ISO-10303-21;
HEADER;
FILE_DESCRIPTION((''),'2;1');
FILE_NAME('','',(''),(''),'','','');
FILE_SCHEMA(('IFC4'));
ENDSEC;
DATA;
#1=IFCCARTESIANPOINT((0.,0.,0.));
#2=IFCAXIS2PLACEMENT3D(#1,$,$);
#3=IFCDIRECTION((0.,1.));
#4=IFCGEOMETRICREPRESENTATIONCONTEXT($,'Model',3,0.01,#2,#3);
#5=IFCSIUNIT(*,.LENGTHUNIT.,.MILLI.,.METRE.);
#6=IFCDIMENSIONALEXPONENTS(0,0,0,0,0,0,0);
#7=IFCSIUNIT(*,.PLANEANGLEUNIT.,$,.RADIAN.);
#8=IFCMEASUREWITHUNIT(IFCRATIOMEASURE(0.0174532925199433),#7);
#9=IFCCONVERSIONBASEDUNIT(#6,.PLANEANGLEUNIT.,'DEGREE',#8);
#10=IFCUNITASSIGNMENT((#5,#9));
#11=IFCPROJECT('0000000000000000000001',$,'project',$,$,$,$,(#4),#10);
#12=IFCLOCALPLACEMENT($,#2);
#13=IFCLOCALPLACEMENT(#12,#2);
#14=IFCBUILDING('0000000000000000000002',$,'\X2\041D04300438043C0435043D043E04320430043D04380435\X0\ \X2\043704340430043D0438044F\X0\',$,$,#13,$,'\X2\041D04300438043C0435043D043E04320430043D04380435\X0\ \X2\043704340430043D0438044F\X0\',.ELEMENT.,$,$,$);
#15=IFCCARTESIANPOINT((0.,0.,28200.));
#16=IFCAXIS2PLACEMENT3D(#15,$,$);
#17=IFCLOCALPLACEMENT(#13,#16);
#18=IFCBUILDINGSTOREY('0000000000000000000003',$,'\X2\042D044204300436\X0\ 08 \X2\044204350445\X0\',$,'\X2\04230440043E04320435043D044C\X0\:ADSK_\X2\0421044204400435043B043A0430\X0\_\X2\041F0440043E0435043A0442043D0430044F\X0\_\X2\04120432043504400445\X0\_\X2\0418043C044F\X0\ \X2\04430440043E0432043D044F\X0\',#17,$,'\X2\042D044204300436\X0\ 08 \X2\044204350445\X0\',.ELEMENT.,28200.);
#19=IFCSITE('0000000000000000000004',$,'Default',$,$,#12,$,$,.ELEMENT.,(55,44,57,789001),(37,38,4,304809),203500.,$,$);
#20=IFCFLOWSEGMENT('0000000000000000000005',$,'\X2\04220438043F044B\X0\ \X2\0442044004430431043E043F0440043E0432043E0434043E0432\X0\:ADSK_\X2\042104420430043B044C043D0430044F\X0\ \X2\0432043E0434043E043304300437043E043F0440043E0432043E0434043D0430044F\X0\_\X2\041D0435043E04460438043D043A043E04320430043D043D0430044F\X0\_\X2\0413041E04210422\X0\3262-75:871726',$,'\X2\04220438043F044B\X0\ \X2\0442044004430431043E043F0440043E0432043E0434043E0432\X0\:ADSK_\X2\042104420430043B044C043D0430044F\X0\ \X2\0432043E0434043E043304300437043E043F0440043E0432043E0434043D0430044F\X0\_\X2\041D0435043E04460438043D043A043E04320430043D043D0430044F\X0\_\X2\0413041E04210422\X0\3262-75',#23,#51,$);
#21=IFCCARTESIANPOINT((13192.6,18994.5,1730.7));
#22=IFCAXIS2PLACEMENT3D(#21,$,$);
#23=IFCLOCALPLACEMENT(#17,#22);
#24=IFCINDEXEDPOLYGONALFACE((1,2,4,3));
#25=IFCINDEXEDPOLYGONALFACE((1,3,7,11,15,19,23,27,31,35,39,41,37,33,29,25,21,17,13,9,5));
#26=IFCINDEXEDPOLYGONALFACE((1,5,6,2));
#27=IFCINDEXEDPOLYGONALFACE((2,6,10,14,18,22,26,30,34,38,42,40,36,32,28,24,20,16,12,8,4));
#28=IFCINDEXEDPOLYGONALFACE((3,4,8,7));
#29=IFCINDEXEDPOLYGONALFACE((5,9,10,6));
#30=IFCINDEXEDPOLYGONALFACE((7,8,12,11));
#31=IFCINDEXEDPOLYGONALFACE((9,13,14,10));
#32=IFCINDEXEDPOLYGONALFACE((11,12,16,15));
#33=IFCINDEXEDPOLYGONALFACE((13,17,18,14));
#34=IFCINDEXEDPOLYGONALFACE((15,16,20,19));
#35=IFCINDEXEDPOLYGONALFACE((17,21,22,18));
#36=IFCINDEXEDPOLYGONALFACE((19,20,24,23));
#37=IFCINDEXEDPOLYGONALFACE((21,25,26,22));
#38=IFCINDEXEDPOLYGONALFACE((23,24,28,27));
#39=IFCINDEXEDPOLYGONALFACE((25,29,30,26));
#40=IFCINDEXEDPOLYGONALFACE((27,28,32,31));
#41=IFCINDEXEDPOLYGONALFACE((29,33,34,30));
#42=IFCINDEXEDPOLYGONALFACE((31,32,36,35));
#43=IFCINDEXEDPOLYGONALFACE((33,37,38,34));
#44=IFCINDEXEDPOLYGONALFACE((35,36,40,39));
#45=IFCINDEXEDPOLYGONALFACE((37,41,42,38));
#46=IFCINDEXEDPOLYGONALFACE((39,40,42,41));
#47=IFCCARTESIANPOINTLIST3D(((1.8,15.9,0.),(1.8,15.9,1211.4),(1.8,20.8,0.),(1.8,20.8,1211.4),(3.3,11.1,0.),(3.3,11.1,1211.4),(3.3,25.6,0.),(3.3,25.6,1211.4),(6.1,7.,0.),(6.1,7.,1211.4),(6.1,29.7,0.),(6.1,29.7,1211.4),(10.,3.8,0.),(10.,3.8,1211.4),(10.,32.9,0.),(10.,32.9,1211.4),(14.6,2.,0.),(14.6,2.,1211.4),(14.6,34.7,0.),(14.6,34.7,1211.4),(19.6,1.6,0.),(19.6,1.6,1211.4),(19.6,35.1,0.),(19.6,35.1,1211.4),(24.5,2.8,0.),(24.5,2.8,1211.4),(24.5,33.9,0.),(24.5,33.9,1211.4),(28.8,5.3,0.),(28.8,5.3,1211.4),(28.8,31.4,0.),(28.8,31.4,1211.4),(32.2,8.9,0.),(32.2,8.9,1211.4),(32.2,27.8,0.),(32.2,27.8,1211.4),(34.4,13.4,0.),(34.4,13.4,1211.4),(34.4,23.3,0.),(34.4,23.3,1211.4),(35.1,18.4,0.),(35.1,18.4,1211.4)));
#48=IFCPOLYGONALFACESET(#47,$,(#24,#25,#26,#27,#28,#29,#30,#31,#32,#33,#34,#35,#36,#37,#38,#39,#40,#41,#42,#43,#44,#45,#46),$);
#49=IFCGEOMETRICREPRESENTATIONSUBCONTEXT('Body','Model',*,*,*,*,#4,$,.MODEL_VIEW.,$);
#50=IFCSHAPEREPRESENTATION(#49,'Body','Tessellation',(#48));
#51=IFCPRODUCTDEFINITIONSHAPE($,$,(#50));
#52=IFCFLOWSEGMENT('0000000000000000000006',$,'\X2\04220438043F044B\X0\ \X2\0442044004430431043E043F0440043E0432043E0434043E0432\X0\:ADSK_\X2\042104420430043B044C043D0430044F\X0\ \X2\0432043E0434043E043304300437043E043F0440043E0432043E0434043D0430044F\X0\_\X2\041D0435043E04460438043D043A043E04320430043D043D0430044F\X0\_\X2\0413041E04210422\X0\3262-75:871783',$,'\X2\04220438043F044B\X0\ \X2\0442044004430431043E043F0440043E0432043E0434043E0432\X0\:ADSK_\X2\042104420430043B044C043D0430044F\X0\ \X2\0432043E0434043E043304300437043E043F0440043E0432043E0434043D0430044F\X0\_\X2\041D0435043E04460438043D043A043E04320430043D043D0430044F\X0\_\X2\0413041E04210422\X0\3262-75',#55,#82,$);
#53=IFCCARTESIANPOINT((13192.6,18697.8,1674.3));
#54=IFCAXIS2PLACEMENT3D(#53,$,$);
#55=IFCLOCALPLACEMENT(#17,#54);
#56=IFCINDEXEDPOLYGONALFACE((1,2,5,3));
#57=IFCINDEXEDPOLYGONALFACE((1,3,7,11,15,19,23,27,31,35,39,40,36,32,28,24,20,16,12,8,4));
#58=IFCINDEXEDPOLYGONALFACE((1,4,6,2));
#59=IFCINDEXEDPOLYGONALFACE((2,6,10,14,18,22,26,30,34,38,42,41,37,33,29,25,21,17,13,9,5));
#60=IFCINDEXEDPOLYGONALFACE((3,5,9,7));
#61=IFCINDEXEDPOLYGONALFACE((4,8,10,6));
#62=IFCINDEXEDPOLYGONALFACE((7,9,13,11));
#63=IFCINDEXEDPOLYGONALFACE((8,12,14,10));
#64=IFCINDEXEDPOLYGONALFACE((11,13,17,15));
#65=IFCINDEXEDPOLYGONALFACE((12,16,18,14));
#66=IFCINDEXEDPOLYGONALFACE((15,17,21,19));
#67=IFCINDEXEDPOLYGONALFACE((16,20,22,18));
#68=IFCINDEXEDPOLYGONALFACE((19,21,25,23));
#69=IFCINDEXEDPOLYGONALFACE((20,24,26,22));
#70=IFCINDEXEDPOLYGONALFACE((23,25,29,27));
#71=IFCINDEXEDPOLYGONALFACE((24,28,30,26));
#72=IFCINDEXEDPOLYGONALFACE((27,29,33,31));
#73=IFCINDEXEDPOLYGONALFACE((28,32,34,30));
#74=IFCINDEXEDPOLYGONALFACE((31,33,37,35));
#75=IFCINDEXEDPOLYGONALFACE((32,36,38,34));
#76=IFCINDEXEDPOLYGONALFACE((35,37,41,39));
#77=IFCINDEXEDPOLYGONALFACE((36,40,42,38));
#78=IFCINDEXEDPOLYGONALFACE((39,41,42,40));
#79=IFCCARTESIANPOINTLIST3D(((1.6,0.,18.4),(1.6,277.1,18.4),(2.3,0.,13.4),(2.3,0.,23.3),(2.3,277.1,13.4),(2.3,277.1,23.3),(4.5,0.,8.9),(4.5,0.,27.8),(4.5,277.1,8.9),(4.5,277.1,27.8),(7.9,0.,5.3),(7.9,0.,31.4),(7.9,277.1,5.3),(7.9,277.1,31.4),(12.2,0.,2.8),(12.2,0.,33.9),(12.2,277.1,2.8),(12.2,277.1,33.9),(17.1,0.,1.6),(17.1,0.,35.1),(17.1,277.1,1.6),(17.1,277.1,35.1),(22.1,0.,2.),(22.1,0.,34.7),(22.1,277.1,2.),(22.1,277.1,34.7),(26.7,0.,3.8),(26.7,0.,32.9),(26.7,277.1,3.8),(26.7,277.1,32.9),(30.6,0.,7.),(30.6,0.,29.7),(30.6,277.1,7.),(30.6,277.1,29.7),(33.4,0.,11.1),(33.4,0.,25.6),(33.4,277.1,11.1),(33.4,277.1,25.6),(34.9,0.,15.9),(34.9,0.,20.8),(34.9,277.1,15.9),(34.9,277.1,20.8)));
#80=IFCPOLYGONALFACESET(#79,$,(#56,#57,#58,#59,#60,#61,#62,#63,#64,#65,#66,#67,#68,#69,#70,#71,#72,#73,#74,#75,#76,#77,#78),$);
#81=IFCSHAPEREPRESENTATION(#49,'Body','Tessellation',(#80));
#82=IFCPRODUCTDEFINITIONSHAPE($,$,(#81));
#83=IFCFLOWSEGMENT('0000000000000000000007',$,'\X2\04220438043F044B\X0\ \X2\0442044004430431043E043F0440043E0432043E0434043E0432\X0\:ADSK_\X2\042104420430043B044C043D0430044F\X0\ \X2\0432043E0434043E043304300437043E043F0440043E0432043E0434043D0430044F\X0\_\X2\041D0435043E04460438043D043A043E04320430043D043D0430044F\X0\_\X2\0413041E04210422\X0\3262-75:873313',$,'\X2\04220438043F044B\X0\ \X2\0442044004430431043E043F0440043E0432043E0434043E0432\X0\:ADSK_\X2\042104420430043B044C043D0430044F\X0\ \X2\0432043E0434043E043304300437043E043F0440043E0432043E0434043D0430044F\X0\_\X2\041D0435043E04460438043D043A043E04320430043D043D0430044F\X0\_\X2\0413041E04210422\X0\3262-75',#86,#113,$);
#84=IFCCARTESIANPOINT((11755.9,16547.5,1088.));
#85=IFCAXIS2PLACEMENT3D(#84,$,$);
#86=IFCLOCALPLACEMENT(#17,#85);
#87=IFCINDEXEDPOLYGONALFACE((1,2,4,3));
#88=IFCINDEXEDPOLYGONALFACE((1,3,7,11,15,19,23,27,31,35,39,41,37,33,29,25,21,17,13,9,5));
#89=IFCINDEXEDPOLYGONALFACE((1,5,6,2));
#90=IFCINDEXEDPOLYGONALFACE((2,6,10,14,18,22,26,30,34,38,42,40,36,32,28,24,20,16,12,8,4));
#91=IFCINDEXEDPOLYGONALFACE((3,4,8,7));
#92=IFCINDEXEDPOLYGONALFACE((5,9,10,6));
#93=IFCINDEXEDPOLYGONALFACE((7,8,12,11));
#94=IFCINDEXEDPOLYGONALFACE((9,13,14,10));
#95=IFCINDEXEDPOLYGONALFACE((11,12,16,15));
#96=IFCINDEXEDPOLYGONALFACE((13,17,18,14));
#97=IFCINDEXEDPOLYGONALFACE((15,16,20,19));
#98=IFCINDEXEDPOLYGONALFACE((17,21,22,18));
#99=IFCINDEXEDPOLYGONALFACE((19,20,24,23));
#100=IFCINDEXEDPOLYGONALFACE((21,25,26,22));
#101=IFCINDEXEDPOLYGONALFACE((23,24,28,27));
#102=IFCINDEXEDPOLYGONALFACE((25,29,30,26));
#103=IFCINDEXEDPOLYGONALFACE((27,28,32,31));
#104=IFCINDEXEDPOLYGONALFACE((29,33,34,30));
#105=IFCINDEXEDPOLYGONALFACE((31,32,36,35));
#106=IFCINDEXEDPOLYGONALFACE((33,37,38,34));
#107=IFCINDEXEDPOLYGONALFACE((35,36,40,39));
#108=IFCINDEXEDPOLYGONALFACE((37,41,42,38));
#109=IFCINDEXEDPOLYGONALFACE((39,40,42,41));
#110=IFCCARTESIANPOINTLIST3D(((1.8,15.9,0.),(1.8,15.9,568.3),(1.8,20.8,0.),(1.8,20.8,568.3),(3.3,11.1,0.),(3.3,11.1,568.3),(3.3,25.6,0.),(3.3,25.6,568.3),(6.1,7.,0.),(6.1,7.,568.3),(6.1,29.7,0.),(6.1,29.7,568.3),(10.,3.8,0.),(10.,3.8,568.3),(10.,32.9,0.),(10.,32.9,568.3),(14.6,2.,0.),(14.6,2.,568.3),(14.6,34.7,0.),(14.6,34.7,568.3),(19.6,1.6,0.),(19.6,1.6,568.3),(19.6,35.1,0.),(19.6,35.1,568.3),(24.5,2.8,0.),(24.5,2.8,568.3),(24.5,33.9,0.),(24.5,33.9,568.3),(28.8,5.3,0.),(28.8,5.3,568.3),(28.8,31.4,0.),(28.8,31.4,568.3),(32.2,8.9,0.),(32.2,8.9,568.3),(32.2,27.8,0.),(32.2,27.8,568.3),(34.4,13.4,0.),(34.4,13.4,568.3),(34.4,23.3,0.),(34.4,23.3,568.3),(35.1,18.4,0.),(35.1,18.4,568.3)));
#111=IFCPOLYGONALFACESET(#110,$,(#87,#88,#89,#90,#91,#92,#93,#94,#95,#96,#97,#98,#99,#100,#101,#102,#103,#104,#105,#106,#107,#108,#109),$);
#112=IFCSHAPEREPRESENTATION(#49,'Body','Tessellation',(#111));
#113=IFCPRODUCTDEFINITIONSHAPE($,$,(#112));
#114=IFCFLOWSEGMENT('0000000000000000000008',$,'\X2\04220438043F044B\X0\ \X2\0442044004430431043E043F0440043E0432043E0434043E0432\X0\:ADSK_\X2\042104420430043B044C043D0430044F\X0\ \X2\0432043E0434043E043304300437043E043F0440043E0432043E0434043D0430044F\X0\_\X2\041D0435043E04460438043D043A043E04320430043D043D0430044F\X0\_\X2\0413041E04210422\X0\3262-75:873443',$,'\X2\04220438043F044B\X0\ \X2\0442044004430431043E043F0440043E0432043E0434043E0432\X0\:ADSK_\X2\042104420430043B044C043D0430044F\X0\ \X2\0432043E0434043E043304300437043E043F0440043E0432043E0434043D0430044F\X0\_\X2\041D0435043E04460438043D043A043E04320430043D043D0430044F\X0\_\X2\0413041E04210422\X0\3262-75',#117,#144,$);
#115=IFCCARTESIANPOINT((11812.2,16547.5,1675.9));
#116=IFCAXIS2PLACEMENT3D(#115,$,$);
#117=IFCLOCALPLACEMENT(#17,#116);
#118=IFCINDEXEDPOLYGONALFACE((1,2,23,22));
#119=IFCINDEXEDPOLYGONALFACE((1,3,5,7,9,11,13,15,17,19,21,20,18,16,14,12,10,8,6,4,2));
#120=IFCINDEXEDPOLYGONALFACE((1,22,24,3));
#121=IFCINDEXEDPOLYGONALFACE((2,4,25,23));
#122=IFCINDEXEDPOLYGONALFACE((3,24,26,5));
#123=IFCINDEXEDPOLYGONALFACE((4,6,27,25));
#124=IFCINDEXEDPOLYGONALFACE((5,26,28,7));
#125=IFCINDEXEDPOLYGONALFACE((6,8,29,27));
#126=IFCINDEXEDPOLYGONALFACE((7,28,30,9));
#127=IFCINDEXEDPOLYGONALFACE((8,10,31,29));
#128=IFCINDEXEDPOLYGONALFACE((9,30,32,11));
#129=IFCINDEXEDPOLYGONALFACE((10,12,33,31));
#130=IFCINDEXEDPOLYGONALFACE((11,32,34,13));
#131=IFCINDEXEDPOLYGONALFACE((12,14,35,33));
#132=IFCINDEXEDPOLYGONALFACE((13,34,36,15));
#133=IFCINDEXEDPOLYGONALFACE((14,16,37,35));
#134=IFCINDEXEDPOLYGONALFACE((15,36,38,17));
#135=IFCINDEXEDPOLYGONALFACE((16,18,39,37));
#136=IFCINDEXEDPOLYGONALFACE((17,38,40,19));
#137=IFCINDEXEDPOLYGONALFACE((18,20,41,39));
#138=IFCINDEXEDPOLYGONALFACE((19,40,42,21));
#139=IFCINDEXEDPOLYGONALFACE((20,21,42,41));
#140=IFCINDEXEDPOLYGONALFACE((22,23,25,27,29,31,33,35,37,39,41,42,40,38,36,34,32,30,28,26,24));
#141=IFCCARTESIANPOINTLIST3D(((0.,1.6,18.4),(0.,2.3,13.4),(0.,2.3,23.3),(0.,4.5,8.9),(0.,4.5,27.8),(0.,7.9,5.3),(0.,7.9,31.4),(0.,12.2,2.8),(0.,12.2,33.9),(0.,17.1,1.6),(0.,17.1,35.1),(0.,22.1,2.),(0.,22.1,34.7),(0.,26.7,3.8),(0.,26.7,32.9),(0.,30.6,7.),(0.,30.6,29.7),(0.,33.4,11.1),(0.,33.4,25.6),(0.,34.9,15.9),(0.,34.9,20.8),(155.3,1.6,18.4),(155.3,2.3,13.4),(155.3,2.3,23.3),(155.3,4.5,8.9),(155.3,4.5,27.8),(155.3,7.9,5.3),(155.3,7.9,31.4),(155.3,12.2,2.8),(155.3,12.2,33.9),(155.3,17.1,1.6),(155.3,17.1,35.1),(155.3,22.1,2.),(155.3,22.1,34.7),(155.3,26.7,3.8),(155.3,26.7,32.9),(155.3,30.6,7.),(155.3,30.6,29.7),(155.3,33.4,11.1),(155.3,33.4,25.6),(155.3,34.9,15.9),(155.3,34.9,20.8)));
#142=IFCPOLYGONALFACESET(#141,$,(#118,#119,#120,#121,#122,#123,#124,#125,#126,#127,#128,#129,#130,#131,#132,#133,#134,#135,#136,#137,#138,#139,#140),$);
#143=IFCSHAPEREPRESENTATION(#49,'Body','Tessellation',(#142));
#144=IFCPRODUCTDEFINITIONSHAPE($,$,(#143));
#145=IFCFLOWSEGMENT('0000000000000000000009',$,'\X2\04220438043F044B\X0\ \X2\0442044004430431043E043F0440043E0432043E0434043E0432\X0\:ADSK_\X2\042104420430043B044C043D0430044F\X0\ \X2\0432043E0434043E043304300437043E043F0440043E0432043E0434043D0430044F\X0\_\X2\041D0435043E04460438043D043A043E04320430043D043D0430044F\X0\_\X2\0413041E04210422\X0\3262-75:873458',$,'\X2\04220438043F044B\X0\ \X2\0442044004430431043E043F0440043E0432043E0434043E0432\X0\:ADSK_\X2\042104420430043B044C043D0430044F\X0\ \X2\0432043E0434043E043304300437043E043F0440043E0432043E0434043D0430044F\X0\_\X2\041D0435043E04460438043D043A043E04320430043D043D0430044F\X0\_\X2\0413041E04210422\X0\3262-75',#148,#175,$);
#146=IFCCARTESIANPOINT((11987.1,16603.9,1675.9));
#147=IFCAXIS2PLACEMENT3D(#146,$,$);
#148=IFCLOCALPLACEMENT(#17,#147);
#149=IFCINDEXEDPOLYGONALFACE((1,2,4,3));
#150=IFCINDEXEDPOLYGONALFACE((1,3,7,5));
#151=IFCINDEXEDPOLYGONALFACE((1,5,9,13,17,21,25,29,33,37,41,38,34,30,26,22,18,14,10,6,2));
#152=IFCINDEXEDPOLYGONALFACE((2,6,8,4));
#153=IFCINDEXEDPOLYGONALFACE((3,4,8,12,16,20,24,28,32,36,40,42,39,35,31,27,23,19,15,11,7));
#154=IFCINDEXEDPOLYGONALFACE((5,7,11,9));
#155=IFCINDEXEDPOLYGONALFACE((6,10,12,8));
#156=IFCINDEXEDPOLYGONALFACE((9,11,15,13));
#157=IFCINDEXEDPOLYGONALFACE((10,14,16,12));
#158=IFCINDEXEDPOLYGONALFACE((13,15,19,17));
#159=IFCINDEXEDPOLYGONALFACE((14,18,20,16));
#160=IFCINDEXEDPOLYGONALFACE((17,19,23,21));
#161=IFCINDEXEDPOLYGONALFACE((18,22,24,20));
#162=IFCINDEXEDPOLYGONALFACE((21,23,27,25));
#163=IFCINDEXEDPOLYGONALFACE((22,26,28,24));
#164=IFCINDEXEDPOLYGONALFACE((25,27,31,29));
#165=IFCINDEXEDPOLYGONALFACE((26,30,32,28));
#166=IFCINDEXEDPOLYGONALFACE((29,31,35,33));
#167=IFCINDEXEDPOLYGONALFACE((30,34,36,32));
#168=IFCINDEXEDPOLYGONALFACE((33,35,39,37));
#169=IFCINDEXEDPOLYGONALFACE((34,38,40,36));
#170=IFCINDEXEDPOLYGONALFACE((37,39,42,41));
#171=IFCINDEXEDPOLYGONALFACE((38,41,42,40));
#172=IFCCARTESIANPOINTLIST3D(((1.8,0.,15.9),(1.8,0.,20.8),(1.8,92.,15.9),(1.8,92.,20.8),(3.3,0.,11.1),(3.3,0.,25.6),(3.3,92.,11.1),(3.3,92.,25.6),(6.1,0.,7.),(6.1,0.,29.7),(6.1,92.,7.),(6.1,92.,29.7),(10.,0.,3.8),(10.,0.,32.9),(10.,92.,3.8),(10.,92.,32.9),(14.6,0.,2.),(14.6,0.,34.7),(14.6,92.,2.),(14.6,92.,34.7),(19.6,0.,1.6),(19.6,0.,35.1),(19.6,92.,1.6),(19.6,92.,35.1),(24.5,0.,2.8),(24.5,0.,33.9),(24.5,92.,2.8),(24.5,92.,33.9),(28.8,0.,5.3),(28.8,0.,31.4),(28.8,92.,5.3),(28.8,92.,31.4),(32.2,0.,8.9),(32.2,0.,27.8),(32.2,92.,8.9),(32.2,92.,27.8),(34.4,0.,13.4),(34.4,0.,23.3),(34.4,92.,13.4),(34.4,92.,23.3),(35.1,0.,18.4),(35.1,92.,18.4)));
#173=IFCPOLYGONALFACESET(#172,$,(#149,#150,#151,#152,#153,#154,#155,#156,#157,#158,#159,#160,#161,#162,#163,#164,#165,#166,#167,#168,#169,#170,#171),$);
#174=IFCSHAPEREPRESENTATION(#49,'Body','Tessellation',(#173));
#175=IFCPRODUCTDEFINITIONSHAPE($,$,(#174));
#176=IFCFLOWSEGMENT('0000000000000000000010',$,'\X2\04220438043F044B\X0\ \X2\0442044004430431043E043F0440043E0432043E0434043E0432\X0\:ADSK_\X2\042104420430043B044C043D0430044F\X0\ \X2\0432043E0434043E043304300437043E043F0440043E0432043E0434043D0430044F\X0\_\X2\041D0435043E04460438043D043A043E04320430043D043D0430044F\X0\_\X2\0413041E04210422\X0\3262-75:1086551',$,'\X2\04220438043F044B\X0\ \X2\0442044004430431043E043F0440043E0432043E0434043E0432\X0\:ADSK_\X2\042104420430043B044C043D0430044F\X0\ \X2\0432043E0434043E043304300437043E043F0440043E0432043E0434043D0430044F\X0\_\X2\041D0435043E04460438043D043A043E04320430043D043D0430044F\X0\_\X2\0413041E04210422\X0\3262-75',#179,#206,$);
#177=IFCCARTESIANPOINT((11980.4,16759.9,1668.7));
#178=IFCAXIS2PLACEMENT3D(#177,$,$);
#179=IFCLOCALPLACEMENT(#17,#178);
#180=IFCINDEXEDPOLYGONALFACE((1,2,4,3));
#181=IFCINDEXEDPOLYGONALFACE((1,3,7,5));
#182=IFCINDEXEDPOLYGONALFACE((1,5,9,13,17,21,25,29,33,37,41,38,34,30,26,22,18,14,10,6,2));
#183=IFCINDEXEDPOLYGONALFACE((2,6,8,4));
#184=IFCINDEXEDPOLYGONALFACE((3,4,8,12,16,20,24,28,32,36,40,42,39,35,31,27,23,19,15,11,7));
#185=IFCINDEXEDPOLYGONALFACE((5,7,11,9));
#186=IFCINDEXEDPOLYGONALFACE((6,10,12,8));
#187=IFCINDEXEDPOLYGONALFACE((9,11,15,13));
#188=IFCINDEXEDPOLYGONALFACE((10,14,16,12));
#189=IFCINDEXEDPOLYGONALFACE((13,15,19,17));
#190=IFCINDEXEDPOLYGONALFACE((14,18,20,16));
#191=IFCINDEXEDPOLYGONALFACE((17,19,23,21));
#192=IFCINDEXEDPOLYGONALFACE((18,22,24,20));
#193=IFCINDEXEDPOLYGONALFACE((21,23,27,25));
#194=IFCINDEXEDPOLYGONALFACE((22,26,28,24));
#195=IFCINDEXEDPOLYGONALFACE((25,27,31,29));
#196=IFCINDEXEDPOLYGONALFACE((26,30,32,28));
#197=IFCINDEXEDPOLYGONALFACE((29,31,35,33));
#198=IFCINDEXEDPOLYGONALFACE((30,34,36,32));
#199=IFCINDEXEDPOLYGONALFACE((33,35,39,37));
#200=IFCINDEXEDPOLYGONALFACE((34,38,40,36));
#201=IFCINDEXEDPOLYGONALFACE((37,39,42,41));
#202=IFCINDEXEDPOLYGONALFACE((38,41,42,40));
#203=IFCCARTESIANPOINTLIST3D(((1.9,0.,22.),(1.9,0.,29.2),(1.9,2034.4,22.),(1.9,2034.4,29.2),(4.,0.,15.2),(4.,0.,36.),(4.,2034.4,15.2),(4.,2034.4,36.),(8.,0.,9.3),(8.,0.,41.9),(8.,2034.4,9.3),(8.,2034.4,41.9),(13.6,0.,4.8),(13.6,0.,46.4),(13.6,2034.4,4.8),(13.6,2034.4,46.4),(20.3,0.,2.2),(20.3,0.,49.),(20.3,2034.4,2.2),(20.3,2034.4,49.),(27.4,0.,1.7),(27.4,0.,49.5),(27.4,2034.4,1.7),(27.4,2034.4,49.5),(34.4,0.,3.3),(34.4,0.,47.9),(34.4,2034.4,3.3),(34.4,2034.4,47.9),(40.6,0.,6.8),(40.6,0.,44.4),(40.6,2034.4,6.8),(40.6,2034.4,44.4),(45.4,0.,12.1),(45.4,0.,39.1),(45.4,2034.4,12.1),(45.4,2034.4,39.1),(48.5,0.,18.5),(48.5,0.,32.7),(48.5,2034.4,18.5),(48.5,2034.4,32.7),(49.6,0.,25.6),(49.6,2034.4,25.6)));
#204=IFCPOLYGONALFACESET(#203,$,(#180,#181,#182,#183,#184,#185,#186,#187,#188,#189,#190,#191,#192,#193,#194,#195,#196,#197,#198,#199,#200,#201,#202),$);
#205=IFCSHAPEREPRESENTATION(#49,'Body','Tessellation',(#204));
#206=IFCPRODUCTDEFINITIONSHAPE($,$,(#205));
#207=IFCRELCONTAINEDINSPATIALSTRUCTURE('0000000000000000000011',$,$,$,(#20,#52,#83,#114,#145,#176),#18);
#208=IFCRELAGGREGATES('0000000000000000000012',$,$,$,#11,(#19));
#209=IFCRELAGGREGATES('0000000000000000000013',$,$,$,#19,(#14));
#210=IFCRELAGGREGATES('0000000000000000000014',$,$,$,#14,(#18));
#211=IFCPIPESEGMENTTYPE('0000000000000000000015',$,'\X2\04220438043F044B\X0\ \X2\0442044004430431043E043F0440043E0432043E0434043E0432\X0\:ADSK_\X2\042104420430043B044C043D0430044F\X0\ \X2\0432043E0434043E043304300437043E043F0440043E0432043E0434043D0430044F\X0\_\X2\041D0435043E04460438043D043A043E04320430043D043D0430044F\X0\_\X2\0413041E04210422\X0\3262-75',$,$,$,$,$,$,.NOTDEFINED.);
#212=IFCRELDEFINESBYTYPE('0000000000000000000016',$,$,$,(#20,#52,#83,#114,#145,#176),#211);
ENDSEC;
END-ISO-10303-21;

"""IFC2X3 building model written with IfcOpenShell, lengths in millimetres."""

from ifc_helpers import new_model, entity, si_unit, converted_unit, direction, frame, origin, origin_2d_with_axis, place, context, subcontext, project, spatial, circle, extrude, type_object, element, save


model = new_model("IFC2X3")

# Units and contexts
model_context = context("Model", 3, precision=0.01, world=origin(), true_north=direction((0.0, 1.0)))
body_context = subcontext(model_context, "Body", "Model", "MODEL_VIEW")
ifc_project = project(units=[si_unit("LENGTHUNIT", "METRE", prefix="MILLI"), converted_unit("PLANEANGLEUNIT", "DEGREE", entity("IfcRatioMeasure", 0.0174532925199433), si_unit("PLANEANGLEUNIT", "RADIAN"), dimensions=[0, 0, 0, 0, 0, 0, 0])], contexts=[model_context])

# Site, building, storey
site_placement = place(None, origin())
site = spatial("IfcSite", under=ifc_project, at=site_placement, Name="Default", CompositionType="ELEMENT", RefLatitude=(55, 44, 57, 789001), RefLongitude=(37, 38, 4, 304809), RefElevation=203500.0)
building_placement = place(site_placement, origin())
building = spatial("IfcBuilding", under=site, at=building_placement, Name="Наименование здания", LongName="Наименование здания", CompositionType="ELEMENT")
storey_placement = place(building_placement, frame((0.0, 0.0, 28200.0)))
storey = spatial("IfcBuildingStorey", under=building, at=storey_placement, Name="Этаж 08 тех", ObjectType="Уровень:ADSK_Стрелка_Проектная_Вверх_Имя уровня", LongName="Этаж 08 тех", CompositionType="ELEMENT", Elevation=28200.0)

# Flow segments
pipe_segment_type = type_object("IfcPipeSegmentType", Name="Типы трубопроводов:ADSK_Стальная водогазопроводная_Неоцинкованная_ГОСТ3262-75", PredefinedType="NOTDEFINED")
flow_segment_1_placement = place(storey_placement, frame((13192.6, 18994.5, 1730.7)))
element("IfcFlowSegment", 1, at=flow_segment_1_placement, inside=storey, type_object=pipe_segment_type, Name="Типы трубопроводов:ADSK_Стальная водогазопроводная_Неоцинкованная_ГОСТ3262-75:871726", ObjectType="Типы трубопроводов:ADSK_Стальная водогазопроводная_Неоцинкованная_ГОСТ3262-75", context=body_context, shape_type="SweptSolid", body=[
    extrude(circle(Radius=16.8, at=origin_2d_with_axis()), frame((18.4, 18.4, 0.0)), (0.0, 0.0, 1.0), 1211.4),
])
flow_segment_2_placement = place(storey_placement, frame((13192.6, 18697.8, 1674.3)))
element("IfcFlowSegment", 2, at=flow_segment_2_placement, inside=storey, type_object=pipe_segment_type, Name="Типы трубопроводов:ADSK_Стальная водогазопроводная_Неоцинкованная_ГОСТ3262-75:871783", ObjectType="Типы трубопроводов:ADSK_Стальная водогазопроводная_Неоцинкованная_ГОСТ3262-75", context=body_context, shape_type="SweptSolid", body=[
    extrude(circle(Radius=16.8, at=origin_2d_with_axis()), frame((18.4, 0.0, 18.4), z_axis=(0.0, 1.0, 0.0), x_axis=(-1.0, 0.0, 0.0)), (0.0, 0.0, 1.0), 277.1),
])
flow_segment_3_placement = place(storey_placement, frame((11755.9, 16547.5, 1088.0)))
element("IfcFlowSegment", 3, at=flow_segment_3_placement, inside=storey, type_object=pipe_segment_type, Name="Типы трубопроводов:ADSK_Стальная водогазопроводная_Неоцинкованная_ГОСТ3262-75:873313", ObjectType="Типы трубопроводов:ADSK_Стальная водогазопроводная_Неоцинкованная_ГОСТ3262-75", context=body_context, shape_type="SweptSolid", body=[
    extrude(circle(Radius=16.8, at=origin_2d_with_axis()), frame((18.4, 18.4, 0.0)), (0.0, 0.0, 1.0), 568.3),
])
flow_segment_4_placement = place(storey_placement, frame((11812.2, 16547.5, 1675.9)))
element("IfcFlowSegment", 4, at=flow_segment_4_placement, inside=storey, type_object=pipe_segment_type, Name="Типы трубопроводов:ADSK_Стальная водогазопроводная_Неоцинкованная_ГОСТ3262-75:873443", ObjectType="Типы трубопроводов:ADSK_Стальная водогазопроводная_Неоцинкованная_ГОСТ3262-75", context=body_context, shape_type="SweptSolid", body=[
    extrude(circle(Radius=16.8, at=origin_2d_with_axis()), frame((0.0, 18.4, 18.4), z_axis=(1.0, 0.0, 0.0), x_axis=(0.0, -1.0, 0.0)), (0.0, 0.0, 1.0), 155.3),
])
flow_segment_5_placement = place(storey_placement, frame((11987.1, 16603.9, 1675.9)))
element("IfcFlowSegment", 5, at=flow_segment_5_placement, inside=storey, type_object=pipe_segment_type, Name="Типы трубопроводов:ADSK_Стальная водогазопроводная_Неоцинкованная_ГОСТ3262-75:873458", ObjectType="Типы трубопроводов:ADSK_Стальная водогазопроводная_Неоцинкованная_ГОСТ3262-75", context=body_context, shape_type="SweptSolid", body=[
    extrude(circle(Radius=16.8, at=origin_2d_with_axis()), frame((18.4, 0.0, 18.4), z_axis=(0.0, 1.0, 0.0), x_axis=(1.0, 0.0, 0.0)), (0.0, 0.0, 1.0), 92.0),
])
flow_segment_6_placement = place(storey_placement, frame((11980.4, 16759.9, 1668.7)))
element("IfcFlowSegment", 6, at=flow_segment_6_placement, inside=storey, type_object=pipe_segment_type, Name="Типы трубопроводов:ADSK_Стальная водогазопроводная_Неоцинкованная_ГОСТ3262-75:1086551", ObjectType="Типы трубопроводов:ADSK_Стальная водогазопроводная_Неоцинкованная_ГОСТ3262-75", context=body_context, shape_type="SweptSolid", body=[
    extrude(circle(Radius=24.0, at=origin_2d_with_axis()), frame((25.6, 0.0, 25.6), z_axis=(0.0, 1.0, 0.0), x_axis=(1.0, 0.0, 0.0)), (0.0, 0.0, 1.0), 2034.4),
])

save(model, "model.ifc")
